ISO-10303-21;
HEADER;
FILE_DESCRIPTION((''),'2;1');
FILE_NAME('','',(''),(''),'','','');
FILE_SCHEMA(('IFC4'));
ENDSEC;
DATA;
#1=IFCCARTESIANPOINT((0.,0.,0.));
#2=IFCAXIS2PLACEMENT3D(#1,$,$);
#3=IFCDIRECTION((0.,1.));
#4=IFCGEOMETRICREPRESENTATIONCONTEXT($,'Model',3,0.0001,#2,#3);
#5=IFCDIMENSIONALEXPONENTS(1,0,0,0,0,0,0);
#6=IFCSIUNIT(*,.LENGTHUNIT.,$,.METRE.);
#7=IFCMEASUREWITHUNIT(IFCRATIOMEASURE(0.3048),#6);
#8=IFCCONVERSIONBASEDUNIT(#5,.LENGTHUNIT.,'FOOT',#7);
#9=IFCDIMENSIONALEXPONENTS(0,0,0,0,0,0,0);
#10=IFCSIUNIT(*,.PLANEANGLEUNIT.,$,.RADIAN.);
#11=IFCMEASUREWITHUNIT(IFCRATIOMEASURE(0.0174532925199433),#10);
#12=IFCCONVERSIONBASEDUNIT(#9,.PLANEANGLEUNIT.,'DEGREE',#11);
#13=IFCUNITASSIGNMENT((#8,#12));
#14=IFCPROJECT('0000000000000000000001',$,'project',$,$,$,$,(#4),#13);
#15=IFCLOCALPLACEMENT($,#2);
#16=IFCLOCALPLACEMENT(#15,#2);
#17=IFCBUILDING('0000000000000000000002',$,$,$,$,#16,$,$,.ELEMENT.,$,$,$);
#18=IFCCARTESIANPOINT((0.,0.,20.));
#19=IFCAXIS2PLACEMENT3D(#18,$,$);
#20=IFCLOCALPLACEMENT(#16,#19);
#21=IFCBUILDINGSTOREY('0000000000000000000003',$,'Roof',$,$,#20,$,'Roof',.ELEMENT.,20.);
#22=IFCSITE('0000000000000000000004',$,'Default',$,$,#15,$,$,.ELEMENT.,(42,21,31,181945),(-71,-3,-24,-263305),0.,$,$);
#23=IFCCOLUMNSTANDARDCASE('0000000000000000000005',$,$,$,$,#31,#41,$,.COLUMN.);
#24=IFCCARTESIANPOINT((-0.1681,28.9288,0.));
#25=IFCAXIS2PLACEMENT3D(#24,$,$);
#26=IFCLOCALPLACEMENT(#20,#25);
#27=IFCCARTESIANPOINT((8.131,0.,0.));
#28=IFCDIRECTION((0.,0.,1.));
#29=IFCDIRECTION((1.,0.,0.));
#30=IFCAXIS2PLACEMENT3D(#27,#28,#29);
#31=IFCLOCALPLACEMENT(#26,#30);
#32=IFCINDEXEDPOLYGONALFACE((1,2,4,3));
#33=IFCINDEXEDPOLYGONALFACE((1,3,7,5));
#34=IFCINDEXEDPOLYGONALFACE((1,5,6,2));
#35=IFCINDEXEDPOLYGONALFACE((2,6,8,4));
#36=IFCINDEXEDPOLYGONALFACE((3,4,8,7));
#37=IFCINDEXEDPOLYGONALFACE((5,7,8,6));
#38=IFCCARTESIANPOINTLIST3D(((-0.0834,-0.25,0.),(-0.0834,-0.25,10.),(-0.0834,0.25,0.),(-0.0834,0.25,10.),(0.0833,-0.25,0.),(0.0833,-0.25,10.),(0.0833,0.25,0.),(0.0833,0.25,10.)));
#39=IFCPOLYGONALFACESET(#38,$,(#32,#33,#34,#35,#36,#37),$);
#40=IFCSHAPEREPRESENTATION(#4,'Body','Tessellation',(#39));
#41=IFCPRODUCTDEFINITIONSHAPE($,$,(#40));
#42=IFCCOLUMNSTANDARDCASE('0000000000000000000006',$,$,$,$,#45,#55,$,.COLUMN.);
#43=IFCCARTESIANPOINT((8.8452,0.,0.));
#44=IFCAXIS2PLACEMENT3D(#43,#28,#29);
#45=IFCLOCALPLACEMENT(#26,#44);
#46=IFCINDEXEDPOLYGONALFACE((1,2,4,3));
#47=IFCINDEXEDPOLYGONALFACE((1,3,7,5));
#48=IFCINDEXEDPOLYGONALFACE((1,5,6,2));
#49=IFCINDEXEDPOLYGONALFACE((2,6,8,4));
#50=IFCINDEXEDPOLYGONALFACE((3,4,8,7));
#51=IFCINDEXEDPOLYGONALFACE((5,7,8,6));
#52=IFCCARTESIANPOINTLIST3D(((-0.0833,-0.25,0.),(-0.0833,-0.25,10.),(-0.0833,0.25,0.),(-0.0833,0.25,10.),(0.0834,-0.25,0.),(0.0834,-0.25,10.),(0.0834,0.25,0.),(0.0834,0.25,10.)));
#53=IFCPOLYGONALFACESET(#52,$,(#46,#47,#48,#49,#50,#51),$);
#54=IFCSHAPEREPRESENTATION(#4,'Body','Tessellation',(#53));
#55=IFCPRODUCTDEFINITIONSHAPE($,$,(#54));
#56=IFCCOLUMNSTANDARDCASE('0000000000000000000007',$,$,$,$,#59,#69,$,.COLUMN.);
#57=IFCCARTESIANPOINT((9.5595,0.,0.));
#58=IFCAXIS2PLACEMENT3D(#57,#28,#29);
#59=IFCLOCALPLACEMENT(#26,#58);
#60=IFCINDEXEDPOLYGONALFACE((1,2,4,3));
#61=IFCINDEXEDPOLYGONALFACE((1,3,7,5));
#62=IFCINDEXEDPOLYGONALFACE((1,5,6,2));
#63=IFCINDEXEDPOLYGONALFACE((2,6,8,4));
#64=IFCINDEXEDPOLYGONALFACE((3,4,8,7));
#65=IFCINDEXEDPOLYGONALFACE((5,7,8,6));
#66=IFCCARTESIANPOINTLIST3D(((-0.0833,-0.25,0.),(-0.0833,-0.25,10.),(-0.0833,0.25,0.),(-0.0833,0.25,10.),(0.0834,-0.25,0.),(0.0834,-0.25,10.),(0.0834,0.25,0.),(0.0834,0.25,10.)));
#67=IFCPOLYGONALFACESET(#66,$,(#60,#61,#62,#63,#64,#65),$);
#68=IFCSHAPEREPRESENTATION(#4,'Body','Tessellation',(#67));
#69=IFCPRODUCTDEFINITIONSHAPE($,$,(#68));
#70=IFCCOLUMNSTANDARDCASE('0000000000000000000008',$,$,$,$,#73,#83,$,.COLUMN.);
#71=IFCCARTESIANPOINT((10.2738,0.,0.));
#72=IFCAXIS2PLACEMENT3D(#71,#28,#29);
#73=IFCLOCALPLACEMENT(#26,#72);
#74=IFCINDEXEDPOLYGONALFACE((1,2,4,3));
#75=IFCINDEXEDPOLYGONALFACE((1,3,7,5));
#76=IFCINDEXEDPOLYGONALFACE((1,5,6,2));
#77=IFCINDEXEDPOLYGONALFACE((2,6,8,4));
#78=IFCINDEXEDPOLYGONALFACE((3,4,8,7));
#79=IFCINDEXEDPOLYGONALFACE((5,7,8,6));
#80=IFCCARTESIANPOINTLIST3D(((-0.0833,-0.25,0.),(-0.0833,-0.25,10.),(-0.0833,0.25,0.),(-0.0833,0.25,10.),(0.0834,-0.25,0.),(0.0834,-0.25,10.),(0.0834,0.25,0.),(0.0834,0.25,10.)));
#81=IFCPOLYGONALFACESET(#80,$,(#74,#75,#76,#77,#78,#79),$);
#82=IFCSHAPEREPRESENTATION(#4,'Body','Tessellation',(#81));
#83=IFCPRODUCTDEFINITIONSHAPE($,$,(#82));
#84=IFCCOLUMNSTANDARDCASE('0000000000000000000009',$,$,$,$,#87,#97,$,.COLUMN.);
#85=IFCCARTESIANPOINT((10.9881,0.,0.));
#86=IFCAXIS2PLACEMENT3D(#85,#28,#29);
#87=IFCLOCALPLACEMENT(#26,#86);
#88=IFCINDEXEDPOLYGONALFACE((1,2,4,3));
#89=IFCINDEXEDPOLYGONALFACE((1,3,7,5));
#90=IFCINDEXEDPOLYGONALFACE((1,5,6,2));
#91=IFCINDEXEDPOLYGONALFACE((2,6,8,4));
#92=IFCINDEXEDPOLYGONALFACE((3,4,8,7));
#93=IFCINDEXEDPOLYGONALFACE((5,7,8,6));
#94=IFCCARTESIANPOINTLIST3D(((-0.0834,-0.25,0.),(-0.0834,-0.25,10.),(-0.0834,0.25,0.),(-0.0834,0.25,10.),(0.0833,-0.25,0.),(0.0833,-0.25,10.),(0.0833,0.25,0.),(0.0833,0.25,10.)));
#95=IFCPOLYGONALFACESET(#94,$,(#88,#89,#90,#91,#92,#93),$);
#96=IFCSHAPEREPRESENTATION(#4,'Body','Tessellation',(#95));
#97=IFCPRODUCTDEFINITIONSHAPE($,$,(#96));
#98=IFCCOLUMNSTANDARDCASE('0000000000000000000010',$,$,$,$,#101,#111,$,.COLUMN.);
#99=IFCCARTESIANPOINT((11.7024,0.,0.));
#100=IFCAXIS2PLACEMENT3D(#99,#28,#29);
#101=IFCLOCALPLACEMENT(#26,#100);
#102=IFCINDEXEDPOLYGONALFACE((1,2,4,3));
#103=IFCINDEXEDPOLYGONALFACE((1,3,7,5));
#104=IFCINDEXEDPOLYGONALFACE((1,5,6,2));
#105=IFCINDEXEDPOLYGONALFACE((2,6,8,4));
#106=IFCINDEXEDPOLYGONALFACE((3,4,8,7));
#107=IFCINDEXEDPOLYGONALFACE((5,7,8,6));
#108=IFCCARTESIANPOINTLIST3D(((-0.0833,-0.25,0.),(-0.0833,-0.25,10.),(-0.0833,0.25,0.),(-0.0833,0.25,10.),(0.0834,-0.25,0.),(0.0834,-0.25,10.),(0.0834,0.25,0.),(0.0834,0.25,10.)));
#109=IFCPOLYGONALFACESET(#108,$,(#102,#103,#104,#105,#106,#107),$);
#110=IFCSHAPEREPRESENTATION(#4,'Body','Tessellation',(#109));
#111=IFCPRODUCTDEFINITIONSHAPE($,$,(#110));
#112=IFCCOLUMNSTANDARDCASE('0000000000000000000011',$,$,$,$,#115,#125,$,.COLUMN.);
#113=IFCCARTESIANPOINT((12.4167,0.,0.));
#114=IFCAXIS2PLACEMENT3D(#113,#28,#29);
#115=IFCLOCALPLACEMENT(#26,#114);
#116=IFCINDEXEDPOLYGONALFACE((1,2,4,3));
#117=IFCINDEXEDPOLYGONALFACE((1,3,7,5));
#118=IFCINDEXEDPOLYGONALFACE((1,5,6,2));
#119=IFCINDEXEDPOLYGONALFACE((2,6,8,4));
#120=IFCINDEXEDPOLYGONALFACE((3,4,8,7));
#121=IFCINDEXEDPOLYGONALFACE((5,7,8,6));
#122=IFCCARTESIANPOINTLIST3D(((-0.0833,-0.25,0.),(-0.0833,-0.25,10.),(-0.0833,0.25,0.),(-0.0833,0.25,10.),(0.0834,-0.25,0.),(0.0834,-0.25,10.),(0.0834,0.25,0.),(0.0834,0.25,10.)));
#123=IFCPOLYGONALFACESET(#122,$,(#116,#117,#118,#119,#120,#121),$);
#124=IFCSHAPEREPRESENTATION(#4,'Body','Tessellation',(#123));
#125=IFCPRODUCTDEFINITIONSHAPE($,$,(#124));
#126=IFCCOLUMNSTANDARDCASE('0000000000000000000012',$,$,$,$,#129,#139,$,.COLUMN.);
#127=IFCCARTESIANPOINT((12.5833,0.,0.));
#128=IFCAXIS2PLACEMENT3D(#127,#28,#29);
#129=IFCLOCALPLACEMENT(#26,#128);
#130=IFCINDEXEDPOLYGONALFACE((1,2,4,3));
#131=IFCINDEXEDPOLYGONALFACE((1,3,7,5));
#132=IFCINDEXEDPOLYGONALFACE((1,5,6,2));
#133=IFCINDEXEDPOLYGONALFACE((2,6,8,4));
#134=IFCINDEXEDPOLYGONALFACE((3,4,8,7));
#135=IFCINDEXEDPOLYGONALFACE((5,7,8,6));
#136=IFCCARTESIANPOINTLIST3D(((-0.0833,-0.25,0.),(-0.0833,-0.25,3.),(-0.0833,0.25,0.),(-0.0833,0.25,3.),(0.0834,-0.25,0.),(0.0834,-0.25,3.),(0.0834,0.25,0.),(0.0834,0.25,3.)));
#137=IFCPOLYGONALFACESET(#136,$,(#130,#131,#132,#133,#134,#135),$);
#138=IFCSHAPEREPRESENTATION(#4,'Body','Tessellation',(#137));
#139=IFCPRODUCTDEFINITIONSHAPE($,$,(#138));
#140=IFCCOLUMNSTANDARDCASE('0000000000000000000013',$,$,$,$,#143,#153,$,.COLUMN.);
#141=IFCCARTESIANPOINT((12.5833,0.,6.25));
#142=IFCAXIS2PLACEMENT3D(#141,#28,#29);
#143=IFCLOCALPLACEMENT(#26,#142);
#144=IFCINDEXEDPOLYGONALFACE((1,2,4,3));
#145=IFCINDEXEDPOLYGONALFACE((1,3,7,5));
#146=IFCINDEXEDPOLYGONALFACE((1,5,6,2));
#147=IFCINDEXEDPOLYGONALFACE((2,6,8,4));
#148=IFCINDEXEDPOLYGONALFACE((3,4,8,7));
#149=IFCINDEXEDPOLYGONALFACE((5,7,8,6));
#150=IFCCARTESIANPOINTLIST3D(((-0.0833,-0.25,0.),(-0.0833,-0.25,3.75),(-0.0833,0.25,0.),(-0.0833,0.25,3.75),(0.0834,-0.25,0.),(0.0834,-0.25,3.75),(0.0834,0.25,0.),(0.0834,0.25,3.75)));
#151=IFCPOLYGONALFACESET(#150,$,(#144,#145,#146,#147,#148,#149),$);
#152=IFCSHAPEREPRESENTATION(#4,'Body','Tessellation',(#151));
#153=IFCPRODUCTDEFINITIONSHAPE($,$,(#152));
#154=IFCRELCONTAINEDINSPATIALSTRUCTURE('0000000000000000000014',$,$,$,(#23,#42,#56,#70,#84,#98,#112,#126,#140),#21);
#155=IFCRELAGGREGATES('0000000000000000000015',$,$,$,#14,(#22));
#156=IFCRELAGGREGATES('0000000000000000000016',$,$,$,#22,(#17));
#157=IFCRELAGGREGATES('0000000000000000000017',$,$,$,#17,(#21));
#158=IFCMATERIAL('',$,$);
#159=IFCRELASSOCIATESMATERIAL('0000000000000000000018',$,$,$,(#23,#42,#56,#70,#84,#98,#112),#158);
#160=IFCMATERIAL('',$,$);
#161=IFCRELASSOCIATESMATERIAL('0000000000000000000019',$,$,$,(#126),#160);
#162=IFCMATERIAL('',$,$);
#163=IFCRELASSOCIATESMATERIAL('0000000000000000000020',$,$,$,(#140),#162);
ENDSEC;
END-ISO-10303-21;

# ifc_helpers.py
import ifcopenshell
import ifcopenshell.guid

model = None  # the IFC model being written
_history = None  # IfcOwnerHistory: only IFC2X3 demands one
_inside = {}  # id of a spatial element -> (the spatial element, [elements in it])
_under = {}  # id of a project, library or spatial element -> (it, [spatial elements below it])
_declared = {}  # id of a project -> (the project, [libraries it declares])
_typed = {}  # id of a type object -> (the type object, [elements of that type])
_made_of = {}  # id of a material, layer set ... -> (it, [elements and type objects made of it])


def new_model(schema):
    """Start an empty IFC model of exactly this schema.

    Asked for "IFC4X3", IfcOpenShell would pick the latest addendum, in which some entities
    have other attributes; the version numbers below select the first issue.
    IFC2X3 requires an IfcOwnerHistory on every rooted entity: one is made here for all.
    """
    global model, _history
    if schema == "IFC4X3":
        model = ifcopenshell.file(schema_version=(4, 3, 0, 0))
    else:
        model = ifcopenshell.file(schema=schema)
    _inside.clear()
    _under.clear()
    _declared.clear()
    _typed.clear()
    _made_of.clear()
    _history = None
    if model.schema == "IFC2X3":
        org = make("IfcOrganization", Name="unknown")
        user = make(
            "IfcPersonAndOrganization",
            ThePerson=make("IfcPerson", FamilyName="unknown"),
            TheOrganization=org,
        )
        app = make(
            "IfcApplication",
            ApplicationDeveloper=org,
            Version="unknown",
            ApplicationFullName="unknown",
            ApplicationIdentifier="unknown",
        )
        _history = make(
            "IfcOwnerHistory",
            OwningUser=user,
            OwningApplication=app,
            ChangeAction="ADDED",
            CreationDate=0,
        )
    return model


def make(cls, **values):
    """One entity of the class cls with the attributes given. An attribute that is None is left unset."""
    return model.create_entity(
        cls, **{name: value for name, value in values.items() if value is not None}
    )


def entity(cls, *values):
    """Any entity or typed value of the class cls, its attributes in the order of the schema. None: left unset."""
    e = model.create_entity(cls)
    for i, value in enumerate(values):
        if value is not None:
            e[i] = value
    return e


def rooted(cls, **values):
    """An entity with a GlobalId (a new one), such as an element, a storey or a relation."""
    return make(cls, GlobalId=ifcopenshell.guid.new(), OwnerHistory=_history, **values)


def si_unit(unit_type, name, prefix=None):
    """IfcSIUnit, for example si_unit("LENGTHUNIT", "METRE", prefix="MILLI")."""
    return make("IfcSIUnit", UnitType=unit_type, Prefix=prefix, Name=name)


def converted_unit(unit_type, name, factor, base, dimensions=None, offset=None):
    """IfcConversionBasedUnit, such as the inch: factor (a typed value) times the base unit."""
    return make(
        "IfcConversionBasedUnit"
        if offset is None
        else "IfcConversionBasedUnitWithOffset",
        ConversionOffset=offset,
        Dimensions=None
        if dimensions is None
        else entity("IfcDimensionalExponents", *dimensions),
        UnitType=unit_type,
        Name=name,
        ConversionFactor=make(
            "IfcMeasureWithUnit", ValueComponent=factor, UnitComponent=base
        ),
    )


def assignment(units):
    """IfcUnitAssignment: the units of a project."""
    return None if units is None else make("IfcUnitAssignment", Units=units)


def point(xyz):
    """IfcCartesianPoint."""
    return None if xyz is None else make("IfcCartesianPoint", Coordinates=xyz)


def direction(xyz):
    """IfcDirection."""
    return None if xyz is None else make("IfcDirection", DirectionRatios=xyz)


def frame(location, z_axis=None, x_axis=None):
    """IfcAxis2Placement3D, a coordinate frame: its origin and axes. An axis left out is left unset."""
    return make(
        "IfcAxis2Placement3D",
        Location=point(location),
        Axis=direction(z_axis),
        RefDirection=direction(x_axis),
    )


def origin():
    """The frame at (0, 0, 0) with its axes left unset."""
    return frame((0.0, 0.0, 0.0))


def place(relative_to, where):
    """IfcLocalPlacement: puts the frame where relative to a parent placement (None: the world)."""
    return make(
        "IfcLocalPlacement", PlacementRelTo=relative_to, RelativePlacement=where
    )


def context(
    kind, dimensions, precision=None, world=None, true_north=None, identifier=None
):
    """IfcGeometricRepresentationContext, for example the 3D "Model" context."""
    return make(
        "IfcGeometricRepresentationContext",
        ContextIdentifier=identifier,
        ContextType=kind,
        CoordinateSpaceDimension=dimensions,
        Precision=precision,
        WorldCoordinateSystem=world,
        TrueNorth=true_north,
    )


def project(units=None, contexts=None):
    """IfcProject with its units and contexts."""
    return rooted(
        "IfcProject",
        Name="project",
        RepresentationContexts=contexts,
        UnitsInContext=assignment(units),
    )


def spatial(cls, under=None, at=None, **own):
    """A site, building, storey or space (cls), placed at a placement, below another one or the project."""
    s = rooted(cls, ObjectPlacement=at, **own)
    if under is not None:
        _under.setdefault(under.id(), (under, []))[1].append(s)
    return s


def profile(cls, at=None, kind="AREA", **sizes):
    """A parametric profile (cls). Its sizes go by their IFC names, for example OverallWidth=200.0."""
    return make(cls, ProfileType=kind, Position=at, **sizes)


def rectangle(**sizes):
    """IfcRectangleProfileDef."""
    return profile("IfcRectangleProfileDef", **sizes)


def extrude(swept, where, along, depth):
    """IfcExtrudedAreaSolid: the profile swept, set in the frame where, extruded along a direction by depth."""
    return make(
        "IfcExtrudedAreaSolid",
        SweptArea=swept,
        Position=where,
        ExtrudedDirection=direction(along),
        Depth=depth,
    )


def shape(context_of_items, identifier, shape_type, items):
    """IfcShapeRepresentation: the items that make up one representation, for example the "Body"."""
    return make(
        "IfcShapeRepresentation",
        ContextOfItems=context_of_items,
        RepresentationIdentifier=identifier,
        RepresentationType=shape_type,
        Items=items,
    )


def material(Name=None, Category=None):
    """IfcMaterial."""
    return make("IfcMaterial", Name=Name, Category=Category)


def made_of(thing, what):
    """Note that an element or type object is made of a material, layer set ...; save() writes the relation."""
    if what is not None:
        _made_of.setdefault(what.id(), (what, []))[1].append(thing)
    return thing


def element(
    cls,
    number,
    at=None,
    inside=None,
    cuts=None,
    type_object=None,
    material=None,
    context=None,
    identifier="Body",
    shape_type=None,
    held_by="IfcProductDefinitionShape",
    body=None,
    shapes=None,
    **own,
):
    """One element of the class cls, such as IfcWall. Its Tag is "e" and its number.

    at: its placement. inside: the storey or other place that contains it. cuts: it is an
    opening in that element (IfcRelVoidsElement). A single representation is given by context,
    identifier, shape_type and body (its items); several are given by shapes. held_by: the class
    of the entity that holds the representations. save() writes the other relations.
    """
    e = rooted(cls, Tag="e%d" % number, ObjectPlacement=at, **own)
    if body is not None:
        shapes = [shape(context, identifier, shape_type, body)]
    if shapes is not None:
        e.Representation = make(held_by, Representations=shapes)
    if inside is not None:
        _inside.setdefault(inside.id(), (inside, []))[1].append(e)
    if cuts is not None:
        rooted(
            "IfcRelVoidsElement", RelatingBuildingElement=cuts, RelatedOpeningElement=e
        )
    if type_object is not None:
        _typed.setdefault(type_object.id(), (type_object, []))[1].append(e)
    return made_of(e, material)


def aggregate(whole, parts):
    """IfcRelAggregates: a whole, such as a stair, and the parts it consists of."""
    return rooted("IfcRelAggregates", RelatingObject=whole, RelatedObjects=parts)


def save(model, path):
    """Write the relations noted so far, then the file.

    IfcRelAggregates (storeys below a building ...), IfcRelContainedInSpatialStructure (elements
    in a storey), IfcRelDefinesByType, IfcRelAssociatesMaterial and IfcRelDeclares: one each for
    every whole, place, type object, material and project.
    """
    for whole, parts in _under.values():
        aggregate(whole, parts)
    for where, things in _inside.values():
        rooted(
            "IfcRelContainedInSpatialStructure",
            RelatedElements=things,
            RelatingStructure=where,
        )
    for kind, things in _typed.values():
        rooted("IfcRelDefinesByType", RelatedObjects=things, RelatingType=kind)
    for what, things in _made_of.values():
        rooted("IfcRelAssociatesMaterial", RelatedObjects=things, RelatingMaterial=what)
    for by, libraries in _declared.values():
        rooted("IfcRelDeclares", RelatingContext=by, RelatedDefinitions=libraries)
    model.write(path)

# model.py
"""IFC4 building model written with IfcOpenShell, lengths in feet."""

from ifc_helpers import new_model, entity, si_unit, converted_unit, direction, frame, origin, place, context, project, spatial, rectangle, extrude, material, element, save


model = new_model("IFC4")

# Units and contexts
model_context = context("Model", 3, precision=0.0001, world=origin(), true_north=direction((0.0, 1.0)))
ifc_project = project(units=[converted_unit("LENGTHUNIT", "FOOT", entity("IfcRatioMeasure", 0.3048), si_unit("LENGTHUNIT", "METRE"), dimensions=[1, 0, 0, 0, 0, 0, 0]), converted_unit("PLANEANGLEUNIT", "DEGREE", entity("IfcRatioMeasure", 0.0174532925199433), si_unit("PLANEANGLEUNIT", "RADIAN"), dimensions=[0, 0, 0, 0, 0, 0, 0])], contexts=[model_context])

# Site, building, storey
site_placement = place(None, origin())
site = spatial("IfcSite", under=ifc_project, at=site_placement, Name="Default", CompositionType="ELEMENT", RefLatitude=(42, 21, 31, 181945), RefLongitude=(-71, -3, -24, -263305), RefElevation=0.0)
building_placement = place(site_placement, origin())
building = spatial("IfcBuilding", under=site, at=building_placement, CompositionType="ELEMENT")
storey_placement = place(building_placement, frame((0.0, 0.0, 20.0)))
storey = spatial("IfcBuildingStorey", under=building, at=storey_placement, Name="Roof", LongName="Roof", CompositionType="ELEMENT", Elevation=20.0)

# Columns
ifc_material_1 = material(Name="")
placement = place(storey_placement, frame((-0.1681, 28.9288, 0.0)))
for number, where, z_axis, x_axis in (
    (1, (8.131, 0.0, 0.0), (0.0, 0.0, 1.0), (1.0, 0.0, 0.0)),
    (2, (8.8452, 0.0, 0.0), (0.0, 0.0, 1.0), (1.0, 0.0, 0.0)),
    (3, (9.5595, 0.0, 0.0), (0.0, 0.0, 1.0), (1.0, 0.0, 0.0)),
    (4, (10.2738, 0.0, 0.0), (0.0, 0.0, 1.0), (1.0, 0.0, 0.0)),
    (5, (10.9881, 0.0, 0.0), (0.0, 0.0, 1.0), (1.0, 0.0, 0.0)),
    (6, (11.7024, 0.0, 0.0), (0.0, 0.0, 1.0), (1.0, 0.0, 0.0)),
    (7, (12.4167, 0.0, 0.0), (0.0, 0.0, 1.0), (1.0, 0.0, 0.0)),
):
    element("IfcColumnStandardCase", number, at=place(placement, frame(where, z_axis=z_axis, x_axis=x_axis)), inside=storey, material=ifc_material_1, PredefinedType="COLUMN", context=model_context, shape_type="SweptSolid", body=[
        extrude(rectangle(XDim=0.1667, YDim=0.5), origin(), (0.0, 0.0, 1.0), 10.0),
    ])
ifc_material_2 = material(Name="")
for number, where, z_axis, x_axis in (
    (8, (12.5833, 0.0, 0.0), (0.0, 0.0, 1.0), (1.0, 0.0, 0.0)),
):
    element("IfcColumnStandardCase", number, at=place(placement, frame(where, z_axis=z_axis, x_axis=x_axis)), inside=storey, material=ifc_material_2, PredefinedType="COLUMN", context=model_context, shape_type="SweptSolid", body=[
        extrude(rectangle(XDim=0.1667, YDim=0.5), origin(), (0.0, 0.0, 1.0), 3.0),
    ])
ifc_material_3 = material(Name="")
for number, where, z_axis, x_axis in (
    (9, (12.5833, 0.0, 6.25), (0.0, 0.0, 1.0), (1.0, 0.0, 0.0)),
):
    element("IfcColumnStandardCase", number, at=place(placement, frame(where, z_axis=z_axis, x_axis=x_axis)), inside=storey, material=ifc_material_3, PredefinedType="COLUMN", context=model_context, shape_type="SweptSolid", body=[
        extrude(rectangle(XDim=0.1667, YDim=0.5), origin(), (0.0, 0.0, 1.0), 3.75),
    ])

save(model, "model.ifc")
